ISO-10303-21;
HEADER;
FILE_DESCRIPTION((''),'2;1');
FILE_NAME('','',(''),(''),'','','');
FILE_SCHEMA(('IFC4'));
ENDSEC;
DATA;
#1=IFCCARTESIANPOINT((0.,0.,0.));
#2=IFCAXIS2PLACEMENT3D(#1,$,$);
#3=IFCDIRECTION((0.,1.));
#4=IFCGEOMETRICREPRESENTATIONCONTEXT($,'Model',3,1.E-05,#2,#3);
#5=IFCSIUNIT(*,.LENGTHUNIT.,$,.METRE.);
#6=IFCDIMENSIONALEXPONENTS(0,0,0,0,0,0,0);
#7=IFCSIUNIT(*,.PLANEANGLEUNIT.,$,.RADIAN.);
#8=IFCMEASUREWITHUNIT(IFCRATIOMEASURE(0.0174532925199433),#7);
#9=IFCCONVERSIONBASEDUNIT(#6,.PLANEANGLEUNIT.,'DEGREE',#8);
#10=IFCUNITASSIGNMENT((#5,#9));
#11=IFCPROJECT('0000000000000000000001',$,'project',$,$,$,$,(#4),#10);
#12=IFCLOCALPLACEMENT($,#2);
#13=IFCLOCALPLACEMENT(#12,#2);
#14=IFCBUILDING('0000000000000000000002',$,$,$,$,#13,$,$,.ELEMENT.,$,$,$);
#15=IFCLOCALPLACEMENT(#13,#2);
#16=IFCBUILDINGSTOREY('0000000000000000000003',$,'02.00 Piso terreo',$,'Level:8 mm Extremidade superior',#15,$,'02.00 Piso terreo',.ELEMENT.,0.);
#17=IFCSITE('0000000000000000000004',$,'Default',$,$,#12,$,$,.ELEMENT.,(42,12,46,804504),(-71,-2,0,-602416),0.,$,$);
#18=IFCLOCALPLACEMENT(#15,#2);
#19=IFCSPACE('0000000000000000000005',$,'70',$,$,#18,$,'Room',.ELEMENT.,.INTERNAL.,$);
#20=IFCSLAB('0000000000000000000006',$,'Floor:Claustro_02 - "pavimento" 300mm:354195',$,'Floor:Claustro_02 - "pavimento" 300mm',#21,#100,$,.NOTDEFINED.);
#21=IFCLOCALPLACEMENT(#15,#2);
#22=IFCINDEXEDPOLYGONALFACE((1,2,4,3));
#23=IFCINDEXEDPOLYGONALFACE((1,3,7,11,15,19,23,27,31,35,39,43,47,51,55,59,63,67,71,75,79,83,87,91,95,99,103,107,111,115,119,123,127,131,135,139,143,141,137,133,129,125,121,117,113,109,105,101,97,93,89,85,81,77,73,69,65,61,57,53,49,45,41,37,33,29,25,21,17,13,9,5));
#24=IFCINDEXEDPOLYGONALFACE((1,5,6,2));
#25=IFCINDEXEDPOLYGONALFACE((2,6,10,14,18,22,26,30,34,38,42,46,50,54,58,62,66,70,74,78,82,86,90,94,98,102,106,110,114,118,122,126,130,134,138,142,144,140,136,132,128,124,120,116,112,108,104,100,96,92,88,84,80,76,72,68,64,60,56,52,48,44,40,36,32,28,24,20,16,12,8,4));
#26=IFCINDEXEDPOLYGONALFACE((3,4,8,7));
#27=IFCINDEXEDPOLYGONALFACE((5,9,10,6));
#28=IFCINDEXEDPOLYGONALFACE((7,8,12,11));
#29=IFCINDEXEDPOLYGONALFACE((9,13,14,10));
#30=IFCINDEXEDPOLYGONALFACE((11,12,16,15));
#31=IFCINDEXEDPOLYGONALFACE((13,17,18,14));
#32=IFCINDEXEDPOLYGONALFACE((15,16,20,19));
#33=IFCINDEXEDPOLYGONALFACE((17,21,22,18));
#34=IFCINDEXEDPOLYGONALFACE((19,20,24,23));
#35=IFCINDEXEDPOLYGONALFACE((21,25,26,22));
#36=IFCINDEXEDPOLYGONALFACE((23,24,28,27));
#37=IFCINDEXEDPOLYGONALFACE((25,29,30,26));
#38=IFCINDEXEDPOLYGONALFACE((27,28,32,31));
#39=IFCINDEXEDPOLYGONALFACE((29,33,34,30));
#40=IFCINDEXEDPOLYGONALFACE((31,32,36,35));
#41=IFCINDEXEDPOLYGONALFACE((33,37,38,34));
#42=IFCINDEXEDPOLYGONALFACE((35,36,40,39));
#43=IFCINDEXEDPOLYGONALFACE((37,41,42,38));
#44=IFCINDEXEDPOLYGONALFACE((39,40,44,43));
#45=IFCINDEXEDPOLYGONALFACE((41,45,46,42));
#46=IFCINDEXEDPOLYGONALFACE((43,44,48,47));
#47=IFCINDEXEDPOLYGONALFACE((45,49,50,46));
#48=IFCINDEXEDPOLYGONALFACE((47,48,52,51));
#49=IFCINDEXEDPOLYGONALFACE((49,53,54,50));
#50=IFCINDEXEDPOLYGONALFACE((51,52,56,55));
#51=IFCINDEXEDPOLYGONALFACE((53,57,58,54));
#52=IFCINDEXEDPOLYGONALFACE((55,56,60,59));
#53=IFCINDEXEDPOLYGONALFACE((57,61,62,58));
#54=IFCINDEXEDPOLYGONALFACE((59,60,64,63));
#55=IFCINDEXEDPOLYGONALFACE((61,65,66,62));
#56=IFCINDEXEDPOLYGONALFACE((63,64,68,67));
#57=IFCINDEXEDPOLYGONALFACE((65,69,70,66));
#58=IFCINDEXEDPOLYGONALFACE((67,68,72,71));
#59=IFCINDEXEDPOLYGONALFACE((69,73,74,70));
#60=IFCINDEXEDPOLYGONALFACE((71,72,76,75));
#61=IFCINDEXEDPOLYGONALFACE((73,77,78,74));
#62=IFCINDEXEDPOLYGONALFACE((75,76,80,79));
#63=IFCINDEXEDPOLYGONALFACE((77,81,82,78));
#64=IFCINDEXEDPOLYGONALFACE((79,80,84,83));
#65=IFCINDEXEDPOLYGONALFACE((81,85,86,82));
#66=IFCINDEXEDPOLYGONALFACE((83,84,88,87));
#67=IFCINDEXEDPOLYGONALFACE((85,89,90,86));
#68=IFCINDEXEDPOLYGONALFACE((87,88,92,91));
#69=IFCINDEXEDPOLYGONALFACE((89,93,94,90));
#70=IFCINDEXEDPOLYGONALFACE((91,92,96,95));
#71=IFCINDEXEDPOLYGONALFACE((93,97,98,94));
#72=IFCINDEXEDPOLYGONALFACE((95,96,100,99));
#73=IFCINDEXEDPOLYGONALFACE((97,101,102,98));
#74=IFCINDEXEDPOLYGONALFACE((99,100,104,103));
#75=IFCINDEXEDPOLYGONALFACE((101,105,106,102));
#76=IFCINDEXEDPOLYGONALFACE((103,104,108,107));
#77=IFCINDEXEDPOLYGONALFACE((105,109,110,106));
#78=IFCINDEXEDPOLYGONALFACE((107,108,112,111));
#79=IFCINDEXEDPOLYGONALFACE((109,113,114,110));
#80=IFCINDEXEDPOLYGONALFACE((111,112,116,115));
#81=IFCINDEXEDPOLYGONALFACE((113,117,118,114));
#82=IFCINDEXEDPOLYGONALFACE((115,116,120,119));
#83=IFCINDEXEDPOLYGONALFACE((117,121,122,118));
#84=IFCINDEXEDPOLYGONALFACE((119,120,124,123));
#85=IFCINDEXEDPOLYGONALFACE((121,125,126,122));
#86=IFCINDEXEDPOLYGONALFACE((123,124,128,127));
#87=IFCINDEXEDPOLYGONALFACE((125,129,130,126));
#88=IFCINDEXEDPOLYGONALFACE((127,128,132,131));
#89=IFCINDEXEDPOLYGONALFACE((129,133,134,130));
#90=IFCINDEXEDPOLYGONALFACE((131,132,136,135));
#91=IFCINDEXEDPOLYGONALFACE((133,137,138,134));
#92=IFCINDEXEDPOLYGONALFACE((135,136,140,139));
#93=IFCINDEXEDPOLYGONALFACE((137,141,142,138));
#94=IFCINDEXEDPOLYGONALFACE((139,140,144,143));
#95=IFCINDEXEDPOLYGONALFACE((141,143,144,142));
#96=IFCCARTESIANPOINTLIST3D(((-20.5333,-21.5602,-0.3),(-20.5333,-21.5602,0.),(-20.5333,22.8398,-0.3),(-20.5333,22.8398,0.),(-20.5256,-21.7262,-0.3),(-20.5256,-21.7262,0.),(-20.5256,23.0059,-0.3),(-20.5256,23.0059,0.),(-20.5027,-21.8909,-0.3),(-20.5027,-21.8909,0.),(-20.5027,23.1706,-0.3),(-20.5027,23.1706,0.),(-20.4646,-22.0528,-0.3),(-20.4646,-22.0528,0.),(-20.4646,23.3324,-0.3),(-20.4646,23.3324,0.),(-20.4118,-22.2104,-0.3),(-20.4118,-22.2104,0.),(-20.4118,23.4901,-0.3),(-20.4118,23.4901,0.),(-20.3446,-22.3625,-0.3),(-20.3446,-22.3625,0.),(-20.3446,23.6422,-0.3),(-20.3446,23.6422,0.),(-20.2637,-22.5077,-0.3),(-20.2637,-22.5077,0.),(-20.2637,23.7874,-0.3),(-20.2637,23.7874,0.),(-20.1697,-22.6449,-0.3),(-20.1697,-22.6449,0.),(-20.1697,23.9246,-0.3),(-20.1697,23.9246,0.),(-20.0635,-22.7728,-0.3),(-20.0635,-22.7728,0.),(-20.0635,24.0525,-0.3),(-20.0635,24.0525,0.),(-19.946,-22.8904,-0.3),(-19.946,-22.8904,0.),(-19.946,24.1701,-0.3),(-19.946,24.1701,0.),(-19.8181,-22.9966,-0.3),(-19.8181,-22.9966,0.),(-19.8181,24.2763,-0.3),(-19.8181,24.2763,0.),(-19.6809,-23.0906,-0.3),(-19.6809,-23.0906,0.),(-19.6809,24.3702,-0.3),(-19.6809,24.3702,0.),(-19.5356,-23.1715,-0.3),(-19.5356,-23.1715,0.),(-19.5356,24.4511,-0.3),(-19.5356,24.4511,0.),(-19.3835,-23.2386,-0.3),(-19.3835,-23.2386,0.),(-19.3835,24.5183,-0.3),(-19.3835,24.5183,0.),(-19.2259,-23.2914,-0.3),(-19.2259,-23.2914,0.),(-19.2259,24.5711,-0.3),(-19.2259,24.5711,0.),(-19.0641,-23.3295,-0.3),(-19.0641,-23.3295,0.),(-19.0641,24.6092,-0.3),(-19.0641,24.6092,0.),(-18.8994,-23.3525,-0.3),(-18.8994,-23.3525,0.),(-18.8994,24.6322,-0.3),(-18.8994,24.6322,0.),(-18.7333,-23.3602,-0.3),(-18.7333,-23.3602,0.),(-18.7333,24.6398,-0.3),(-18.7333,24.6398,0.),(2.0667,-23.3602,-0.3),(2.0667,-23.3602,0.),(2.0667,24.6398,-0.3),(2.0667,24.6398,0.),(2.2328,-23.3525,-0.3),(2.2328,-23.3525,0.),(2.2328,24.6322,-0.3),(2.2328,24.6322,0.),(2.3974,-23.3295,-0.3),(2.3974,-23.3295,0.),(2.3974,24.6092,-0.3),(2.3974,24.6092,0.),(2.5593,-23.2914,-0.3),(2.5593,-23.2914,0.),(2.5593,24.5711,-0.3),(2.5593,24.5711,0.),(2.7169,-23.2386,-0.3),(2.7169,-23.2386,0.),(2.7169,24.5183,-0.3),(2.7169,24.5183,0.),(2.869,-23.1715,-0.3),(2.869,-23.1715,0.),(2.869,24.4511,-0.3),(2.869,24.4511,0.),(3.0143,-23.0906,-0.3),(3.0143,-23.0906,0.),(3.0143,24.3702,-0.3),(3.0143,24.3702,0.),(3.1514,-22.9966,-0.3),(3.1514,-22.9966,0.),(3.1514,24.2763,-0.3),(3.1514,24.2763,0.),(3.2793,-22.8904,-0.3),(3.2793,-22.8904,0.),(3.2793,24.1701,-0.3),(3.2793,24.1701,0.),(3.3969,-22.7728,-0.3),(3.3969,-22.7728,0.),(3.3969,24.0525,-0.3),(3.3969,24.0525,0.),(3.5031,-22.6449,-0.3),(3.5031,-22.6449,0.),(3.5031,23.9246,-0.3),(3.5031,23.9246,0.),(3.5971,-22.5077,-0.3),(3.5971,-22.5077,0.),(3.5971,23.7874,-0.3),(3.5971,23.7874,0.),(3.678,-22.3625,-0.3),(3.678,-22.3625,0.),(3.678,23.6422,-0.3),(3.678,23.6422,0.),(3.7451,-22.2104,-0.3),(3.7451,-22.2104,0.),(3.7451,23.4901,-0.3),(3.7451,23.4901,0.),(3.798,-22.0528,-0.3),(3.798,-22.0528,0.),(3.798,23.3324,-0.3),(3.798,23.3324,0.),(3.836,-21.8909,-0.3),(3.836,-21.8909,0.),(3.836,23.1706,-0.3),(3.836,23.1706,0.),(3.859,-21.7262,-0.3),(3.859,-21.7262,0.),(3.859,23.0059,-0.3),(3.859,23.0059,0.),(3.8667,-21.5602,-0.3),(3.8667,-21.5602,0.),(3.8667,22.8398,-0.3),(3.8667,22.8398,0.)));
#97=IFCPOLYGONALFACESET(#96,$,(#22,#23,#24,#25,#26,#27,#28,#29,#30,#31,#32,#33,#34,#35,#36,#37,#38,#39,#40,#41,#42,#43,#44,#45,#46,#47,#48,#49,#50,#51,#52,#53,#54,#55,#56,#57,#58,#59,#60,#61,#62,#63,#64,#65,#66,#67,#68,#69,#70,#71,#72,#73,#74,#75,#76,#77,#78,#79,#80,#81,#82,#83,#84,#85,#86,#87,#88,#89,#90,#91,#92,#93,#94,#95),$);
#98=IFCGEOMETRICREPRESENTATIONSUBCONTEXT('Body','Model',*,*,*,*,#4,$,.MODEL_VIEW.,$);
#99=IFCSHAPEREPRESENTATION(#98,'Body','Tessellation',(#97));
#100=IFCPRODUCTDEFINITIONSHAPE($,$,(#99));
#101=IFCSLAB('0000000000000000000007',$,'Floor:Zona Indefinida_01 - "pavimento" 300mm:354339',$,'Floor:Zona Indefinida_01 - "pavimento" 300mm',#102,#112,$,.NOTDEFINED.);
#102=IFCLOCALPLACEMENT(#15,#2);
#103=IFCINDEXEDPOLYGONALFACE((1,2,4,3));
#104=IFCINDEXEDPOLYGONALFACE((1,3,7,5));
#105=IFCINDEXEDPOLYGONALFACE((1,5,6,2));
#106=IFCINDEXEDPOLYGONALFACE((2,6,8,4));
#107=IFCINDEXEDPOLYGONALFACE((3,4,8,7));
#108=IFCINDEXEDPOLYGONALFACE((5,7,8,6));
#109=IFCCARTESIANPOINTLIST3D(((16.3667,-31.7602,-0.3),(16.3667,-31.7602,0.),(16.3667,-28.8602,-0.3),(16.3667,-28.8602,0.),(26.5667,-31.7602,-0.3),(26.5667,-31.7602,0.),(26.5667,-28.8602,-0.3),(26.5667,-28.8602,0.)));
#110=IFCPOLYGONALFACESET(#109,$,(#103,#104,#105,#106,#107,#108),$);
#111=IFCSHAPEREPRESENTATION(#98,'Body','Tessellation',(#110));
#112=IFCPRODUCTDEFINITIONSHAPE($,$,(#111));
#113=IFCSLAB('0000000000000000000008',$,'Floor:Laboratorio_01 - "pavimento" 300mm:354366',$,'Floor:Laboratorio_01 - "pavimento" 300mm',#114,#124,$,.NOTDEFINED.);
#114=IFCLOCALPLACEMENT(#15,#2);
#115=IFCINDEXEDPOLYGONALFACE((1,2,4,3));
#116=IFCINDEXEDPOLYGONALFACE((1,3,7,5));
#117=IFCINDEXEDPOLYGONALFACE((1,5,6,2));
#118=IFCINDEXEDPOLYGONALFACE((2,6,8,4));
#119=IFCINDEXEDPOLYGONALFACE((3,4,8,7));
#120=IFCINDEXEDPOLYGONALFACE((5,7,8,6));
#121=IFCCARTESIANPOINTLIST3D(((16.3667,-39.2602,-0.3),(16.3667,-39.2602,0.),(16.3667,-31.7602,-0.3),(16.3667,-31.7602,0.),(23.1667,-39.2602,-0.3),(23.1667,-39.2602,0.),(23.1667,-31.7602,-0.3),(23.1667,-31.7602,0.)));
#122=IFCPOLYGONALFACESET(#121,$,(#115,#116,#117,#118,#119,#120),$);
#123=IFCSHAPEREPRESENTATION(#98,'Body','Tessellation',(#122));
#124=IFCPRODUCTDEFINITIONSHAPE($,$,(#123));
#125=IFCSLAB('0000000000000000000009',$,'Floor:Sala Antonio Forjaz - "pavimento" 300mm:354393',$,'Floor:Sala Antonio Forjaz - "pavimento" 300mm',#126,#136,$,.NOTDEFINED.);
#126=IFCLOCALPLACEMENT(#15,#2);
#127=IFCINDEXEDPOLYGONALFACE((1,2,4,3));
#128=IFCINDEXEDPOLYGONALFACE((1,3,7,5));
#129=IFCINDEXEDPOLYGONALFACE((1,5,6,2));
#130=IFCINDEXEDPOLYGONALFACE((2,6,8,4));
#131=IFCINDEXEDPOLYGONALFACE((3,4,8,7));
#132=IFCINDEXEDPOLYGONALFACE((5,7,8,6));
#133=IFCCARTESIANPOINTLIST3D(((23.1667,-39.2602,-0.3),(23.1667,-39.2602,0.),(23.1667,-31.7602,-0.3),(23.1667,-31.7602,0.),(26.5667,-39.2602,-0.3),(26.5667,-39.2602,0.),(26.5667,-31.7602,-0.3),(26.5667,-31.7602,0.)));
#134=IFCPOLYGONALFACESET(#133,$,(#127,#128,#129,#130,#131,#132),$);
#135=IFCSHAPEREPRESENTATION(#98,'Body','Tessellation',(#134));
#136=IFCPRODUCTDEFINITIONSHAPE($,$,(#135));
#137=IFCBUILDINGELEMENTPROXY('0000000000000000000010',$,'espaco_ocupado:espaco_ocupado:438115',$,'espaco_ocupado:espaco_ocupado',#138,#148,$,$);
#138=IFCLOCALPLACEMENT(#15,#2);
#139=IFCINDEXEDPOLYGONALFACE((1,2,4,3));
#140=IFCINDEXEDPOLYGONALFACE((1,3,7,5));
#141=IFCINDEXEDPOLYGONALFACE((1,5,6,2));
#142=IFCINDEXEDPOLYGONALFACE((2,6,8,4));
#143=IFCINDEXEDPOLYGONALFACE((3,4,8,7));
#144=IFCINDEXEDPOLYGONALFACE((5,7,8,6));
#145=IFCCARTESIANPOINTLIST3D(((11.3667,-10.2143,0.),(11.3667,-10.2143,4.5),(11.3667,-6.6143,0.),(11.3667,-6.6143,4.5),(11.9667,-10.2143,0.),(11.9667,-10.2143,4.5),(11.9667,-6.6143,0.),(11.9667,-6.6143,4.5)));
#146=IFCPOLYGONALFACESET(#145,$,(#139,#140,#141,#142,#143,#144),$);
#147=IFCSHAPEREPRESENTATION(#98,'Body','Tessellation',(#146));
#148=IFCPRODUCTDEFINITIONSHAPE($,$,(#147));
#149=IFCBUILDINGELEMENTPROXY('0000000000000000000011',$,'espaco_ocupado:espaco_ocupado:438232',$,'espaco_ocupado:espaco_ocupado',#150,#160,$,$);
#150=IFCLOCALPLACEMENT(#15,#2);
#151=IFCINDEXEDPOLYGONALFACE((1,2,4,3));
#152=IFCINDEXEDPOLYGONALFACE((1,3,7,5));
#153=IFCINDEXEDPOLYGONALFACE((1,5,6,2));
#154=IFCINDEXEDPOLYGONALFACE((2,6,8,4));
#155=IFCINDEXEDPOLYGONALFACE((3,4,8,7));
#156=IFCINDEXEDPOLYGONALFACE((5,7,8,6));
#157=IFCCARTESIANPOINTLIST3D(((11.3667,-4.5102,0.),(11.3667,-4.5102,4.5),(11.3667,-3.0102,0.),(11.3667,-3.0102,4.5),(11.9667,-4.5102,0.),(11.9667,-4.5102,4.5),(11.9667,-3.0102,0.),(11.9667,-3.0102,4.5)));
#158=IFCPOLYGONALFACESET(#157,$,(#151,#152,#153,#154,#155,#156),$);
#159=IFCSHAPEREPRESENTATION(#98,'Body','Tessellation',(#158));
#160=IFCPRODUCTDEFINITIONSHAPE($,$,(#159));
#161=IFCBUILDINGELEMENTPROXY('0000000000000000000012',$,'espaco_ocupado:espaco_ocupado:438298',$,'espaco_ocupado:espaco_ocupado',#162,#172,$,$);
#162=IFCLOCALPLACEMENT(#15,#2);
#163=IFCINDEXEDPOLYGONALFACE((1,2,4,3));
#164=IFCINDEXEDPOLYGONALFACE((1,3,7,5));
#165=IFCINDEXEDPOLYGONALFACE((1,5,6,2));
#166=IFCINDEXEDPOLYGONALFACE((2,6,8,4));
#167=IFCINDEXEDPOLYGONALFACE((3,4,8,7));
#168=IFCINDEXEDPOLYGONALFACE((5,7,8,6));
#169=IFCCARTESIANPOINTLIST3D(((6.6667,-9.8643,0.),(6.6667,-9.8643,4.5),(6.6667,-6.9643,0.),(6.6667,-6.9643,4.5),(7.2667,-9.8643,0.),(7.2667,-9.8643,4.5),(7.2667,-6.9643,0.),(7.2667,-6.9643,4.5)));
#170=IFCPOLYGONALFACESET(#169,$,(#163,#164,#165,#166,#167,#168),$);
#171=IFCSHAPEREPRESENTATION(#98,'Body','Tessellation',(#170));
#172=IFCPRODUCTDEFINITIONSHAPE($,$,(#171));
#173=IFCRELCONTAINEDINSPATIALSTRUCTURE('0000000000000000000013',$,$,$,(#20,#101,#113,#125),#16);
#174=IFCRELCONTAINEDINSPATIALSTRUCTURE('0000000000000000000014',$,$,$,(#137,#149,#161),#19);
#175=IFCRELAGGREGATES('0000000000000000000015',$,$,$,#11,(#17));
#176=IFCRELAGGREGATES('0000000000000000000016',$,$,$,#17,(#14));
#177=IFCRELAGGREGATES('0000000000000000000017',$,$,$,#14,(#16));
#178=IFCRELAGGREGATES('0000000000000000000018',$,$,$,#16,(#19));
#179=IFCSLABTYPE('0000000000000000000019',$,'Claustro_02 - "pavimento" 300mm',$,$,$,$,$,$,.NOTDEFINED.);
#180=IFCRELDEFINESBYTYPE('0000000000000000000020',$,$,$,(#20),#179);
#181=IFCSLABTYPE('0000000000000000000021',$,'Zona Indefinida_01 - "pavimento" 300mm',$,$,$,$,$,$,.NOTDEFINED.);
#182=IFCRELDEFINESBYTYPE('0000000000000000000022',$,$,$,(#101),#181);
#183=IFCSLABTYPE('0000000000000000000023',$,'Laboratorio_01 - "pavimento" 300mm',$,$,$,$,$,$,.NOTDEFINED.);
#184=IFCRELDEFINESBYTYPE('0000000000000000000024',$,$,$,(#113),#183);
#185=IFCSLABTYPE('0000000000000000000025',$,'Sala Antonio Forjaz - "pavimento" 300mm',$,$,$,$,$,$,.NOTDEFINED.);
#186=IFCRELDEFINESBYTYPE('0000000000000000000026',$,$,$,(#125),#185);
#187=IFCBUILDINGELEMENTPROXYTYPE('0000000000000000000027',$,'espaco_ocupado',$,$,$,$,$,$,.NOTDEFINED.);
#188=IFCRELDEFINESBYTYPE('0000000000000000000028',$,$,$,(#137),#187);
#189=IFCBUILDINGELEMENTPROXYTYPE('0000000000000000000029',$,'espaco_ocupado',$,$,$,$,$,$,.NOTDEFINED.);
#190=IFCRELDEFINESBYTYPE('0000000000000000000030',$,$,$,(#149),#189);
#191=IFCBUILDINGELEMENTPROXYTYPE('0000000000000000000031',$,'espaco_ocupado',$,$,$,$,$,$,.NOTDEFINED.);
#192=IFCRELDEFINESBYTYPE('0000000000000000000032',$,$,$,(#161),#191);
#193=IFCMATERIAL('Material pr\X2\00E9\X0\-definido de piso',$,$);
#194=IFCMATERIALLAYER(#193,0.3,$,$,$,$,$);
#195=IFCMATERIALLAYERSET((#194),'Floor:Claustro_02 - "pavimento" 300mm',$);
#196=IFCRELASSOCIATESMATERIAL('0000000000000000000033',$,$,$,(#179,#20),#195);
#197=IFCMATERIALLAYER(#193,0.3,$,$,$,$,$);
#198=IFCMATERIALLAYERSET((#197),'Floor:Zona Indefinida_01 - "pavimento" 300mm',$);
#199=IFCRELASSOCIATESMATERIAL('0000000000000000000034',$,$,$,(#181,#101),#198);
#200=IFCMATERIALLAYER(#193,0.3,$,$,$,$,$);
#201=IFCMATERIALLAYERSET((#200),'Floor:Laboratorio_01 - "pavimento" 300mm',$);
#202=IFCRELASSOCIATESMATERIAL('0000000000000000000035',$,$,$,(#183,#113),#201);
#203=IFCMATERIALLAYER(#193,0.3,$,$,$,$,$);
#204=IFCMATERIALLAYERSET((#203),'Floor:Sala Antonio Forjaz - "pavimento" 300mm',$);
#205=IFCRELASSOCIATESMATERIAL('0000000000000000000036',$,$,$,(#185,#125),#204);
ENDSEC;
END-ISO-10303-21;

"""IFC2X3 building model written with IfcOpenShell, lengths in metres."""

from ifc_helpers import new_model, entity, si_unit, converted_unit, direction, frame, frame_2d, origin, origin_2d_with_axis, place, context, subcontext, project, spatial, polyline, circle_curve, parameter, trimmed, segment, composite_curve, rectangle, outline, extrude, source, transform, mapped, material, layer, layer_set, layer_usage, type_object, type_shapes, element, save


model = new_model("IFC2X3")

# Units and contexts
model_context = context("Model", 3, precision=1e-05, world=origin(), true_north=direction((0.0, 1.0)))
body_context = subcontext(model_context, "Body", "Model", "MODEL_VIEW")
ifc_project = project(units=[si_unit("LENGTHUNIT", "METRE"), converted_unit("PLANEANGLEUNIT", "DEGREE", entity("IfcRatioMeasure", 0.0174532925199433), si_unit("PLANEANGLEUNIT", "RADIAN"), dimensions=[0, 0, 0, 0, 0, 0, 0])], contexts=[model_context])

# Site, building, storey
site_placement = place(None, origin())
site = spatial("IfcSite", under=ifc_project, at=site_placement, Name="Default", CompositionType="ELEMENT", RefLatitude=(42, 12, 46, 804504), RefLongitude=(-71, -2, 0, -602416), RefElevation=0.0)
building_placement = place(site_placement, origin())
building = spatial("IfcBuilding", under=site, at=building_placement, CompositionType="ELEMENT")
storey_placement = place(building_placement, origin())
storey = spatial("IfcBuildingStorey", under=building, at=storey_placement, Name="02.00 Piso terreo", ObjectType="Level:8 mm Extremidade superior", LongName="02.00 Piso terreo", CompositionType="ELEMENT", Elevation=0.0)

# Shared definitions
ifc_material_1 = material(Name="Material pré-definido de piso")

# Slabs
ifc_layer_1 = layer(ifc_material_1, 0.3)
ifc_layer_set_1 = layer_set([ifc_layer_1], Name="Floor:Claustro_02 - \"pavimento\" 300mm")
ifc_layer_usage_1 = layer_usage(ifc_layer_set_1, "AXIS3", "POSITIVE", 0.0)
slab_type_1 = type_object("IfcSlabType", Name="Claustro_02 - \"pavimento\" 300mm", PredefinedType="NOTDEFINED", material=ifc_layer_set_1)
slab_1_placement = place(storey_placement, origin())
element("IfcSlab", 1, at=slab_1_placement, inside=storey, type_object=slab_type_1, material=ifc_layer_usage_1, Name="Floor:Claustro_02 - \"pavimento\" 300mm:354195", ObjectType="Floor:Claustro_02 - \"pavimento\" 300mm", PredefinedType="NOTDEFINED", context=body_context, shape_type="SweptSolid", body=[
    extrude(outline(composite_curve([segment(trimmed(circle_curve(frame_2d((10.4, 22.2), x_axis=(1.0, 0.0)), 1.8), [parameter(0.0)], [parameter(90.0)], True, "PARAMETER"), True, "CONTINUOUS"), segment(polyline([(10.4, 24.0), (-10.4, 24.0)]), True, "CONTINUOUS"), segment(trimmed(circle_curve(frame_2d((-10.4, 22.2), x_axis=(0.0, 1.0)), 1.8), [parameter(0.0)], [parameter(90.0)], True, "PARAMETER"), True, "CONTINUOUS"), segment(polyline([(-12.2, 22.2), (-12.2, -22.2)]), True, "CONTINUOUS"), segment(trimmed(circle_curve(frame_2d((-10.4, -22.2), x_axis=(-1.0, 0.0)), 1.8), [parameter(0.0)], [parameter(90.0)], True, "PARAMETER"), True, "CONTINUOUS"), segment(polyline([(-10.4, -24.0), (10.4, -24.0)]), True, "CONTINUOUS"), segment(trimmed(circle_curve(frame_2d((10.4, -22.2), x_axis=(0.0, -1.0)), 1.8), [parameter(0.0)], [parameter(90.0)], True, "PARAMETER"), True, "CONTINUOUS"), segment(polyline([(12.2, -22.2), (12.2, 22.2)]), True, "CONTINUOUS")], self_intersect=False)), frame((-8.3333, 0.6398, 0.0), z_axis=(0.0, 0.0, -1.0), x_axis=(-1.0, 0.0, 0.0)), (0.0, 0.0, 1.0), 0.3),
])
ifc_layer_2 = layer(ifc_material_1, 0.3)
ifc_layer_set_2 = layer_set([ifc_layer_2], Name="Floor:Zona Indefinida_01 - \"pavimento\" 300mm")
ifc_layer_usage_2 = layer_usage(ifc_layer_set_2, "AXIS3", "POSITIVE", 0.0)
slab_type_2 = type_object("IfcSlabType", Name="Zona Indefinida_01 - \"pavimento\" 300mm", PredefinedType="NOTDEFINED", material=ifc_layer_set_2)
slab_2_placement = place(storey_placement, origin())
element("IfcSlab", 2, at=slab_2_placement, inside=storey, type_object=slab_type_2, material=ifc_layer_usage_2, Name="Floor:Zona Indefinida_01 - \"pavimento\" 300mm:354339", ObjectType="Floor:Zona Indefinida_01 - \"pavimento\" 300mm", PredefinedType="NOTDEFINED", context=body_context, shape_type="SweptSolid", body=[
    extrude(rectangle(XDim=2.9, YDim=10.2, at=frame_2d((0.0, 0.0), x_axis=(1.0, 0.0))), frame((21.4667, -30.3102, 0.0), z_axis=(0.0, 0.0, -1.0), x_axis=(0.0, 1.0, 0.0)), (0.0, 0.0, 1.0), 0.3),
])
ifc_layer_3 = layer(ifc_material_1, 0.3)
ifc_layer_set_3 = layer_set([ifc_layer_3], Name="Floor:Laboratorio_01 - \"pavimento\" 300mm")
ifc_layer_usage_3 = layer_usage(ifc_layer_set_3, "AXIS3", "POSITIVE", 0.0)
slab_type_3 = type_object("IfcSlabType", Name="Laboratorio_01 - \"pavimento\" 300mm", PredefinedType="NOTDEFINED", material=ifc_layer_set_3)
slab_3_placement = place(storey_placement, origin())
element("IfcSlab", 3, at=slab_3_placement, inside=storey, type_object=slab_type_3, material=ifc_layer_usage_3, Name="Floor:Laboratorio_01 - \"pavimento\" 300mm:354366", ObjectType="Floor:Laboratorio_01 - \"pavimento\" 300mm", PredefinedType="NOTDEFINED", context=body_context, shape_type="SweptSolid", body=[
    extrude(rectangle(XDim=7.5, YDim=6.8, at=frame_2d((0.0, 0.0), x_axis=(1.0, 0.0))), frame((19.7667, -35.5102, 0.0), z_axis=(0.0, 0.0, -1.0), x_axis=(0.0, 1.0, 0.0)), (0.0, 0.0, 1.0), 0.3),
])
ifc_layer_4 = layer(ifc_material_1, 0.3)
ifc_layer_set_4 = layer_set([ifc_layer_4], Name="Floor:Sala Antonio Forjaz - \"pavimento\" 300mm")
ifc_layer_usage_4 = layer_usage(ifc_layer_set_4, "AXIS3", "POSITIVE", 0.0)
slab_type_4 = type_object("IfcSlabType", Name="Sala Antonio Forjaz - \"pavimento\" 300mm", PredefinedType="NOTDEFINED", material=ifc_layer_set_4)
slab_4_placement = place(storey_placement, origin())
element("IfcSlab", 4, at=slab_4_placement, inside=storey, type_object=slab_type_4, material=ifc_layer_usage_4, Name="Floor:Sala Antonio Forjaz - \"pavimento\" 300mm:354393", ObjectType="Floor:Sala Antonio Forjaz - \"pavimento\" 300mm", PredefinedType="NOTDEFINED", context=body_context, shape_type="SweptSolid", body=[
    extrude(rectangle(XDim=7.5, YDim=3.4, at=origin_2d_with_axis()), frame((24.8667, -35.5102, 0.0), z_axis=(0.0, 0.0, -1.0), x_axis=(0.0, 1.0, 0.0)), (0.0, 0.0, 1.0), 0.3),
])

# Shared definitions
space_1_placement = place(storey_placement, origin())
space_1 = spatial("IfcSpace", under=storey, at=space_1_placement, Name="70", LongName="Room", CompositionType="ELEMENT", InteriorOrExteriorSpace="INTERNAL")

# Building element proxies
building_element_proxy_type_1 = type_object("IfcBuildingElementProxyType", Name="espaco_ocupado", PredefinedType="NOTDEFINED")
shared_shape_1 = source(origin(), body_context, "Body", "SweptSolid", [
    extrude(rectangle(XDim=3.6, YDim=0.6, at=origin_2d_with_axis()), frame((0.0, 0.0, 0.0), z_axis=(0.0, 0.0, 1.0), x_axis=(-1.0, 0.0, 0.0)), (0.0, 0.0, 1.0), 4.5),
])
type_shapes(building_element_proxy_type_1, [shared_shape_1])
proxy_1_placement = place(space_1_placement, frame((11.6667, -8.4143, 0.0), z_axis=(0.0, 0.0, 1.0), x_axis=(0.0, -1.0, 0.0)))
element("IfcBuildingElementProxy", 5, at=proxy_1_placement, inside=space_1, type_object=building_element_proxy_type_1, Name="espaco_ocupado:espaco_ocupado:438115", ObjectType="espaco_ocupado:espaco_ocupado", context=body_context, shape_type="MappedRepresentation", body=[
    mapped(shared_shape_1, transform((0.0, 0.0, 0.0), scale=1.0)),
])
building_element_proxy_type_2 = type_object("IfcBuildingElementProxyType", Name="espaco_ocupado", PredefinedType="NOTDEFINED")
shared_shape_2 = source(origin(), body_context, "Body", "SweptSolid", [
    extrude(rectangle(XDim=1.5, YDim=0.6, at=origin_2d_with_axis()), frame((0.0, 0.0, 0.0), z_axis=(0.0, 0.0, 1.0), x_axis=(-1.0, 0.0, 0.0)), (0.0, 0.0, 1.0), 4.5),
])
type_shapes(building_element_proxy_type_2, [shared_shape_2])
proxy_2_placement = place(space_1_placement, frame((11.6667, -3.7602, 0.0), z_axis=(0.0, 0.0, 1.0), x_axis=(0.0, -1.0, 0.0)))
element("IfcBuildingElementProxy", 6, at=proxy_2_placement, inside=space_1, type_object=building_element_proxy_type_2, Name="espaco_ocupado:espaco_ocupado:438232", ObjectType="espaco_ocupado:espaco_ocupado", context=body_context, shape_type="MappedRepresentation", body=[
    mapped(shared_shape_2, transform((0.0, 0.0, 0.0), scale=1.0)),
])
building_element_proxy_type_3 = type_object("IfcBuildingElementProxyType", Name="espaco_ocupado", PredefinedType="NOTDEFINED")
shared_shape_3 = source(origin(), body_context, "Body", "SweptSolid", [
    extrude(rectangle(XDim=2.9, YDim=0.6, at=origin_2d_with_axis()), frame((0.0, 0.0, 0.0), z_axis=(0.0, 0.0, 1.0), x_axis=(-1.0, 0.0, 0.0)), (0.0, 0.0, 1.0), 4.5),
])
type_shapes(building_element_proxy_type_3, [shared_shape_3])
proxy_3_placement = place(space_1_placement, frame((6.9667, -8.4143, 0.0), z_axis=(0.0, 0.0, 1.0), x_axis=(0.0, -1.0, 0.0)))
element("IfcBuildingElementProxy", 7, at=proxy_3_placement, inside=space_1, type_object=building_element_proxy_type_3, Name="espaco_ocupado:espaco_ocupado:438298", ObjectType="espaco_ocupado:espaco_ocupado", context=body_context, shape_type="MappedRepresentation", body=[
    mapped(shared_shape_3, transform((0.0, 0.0, 0.0), scale=1.0)),
])

save(model, "model.ifc")
